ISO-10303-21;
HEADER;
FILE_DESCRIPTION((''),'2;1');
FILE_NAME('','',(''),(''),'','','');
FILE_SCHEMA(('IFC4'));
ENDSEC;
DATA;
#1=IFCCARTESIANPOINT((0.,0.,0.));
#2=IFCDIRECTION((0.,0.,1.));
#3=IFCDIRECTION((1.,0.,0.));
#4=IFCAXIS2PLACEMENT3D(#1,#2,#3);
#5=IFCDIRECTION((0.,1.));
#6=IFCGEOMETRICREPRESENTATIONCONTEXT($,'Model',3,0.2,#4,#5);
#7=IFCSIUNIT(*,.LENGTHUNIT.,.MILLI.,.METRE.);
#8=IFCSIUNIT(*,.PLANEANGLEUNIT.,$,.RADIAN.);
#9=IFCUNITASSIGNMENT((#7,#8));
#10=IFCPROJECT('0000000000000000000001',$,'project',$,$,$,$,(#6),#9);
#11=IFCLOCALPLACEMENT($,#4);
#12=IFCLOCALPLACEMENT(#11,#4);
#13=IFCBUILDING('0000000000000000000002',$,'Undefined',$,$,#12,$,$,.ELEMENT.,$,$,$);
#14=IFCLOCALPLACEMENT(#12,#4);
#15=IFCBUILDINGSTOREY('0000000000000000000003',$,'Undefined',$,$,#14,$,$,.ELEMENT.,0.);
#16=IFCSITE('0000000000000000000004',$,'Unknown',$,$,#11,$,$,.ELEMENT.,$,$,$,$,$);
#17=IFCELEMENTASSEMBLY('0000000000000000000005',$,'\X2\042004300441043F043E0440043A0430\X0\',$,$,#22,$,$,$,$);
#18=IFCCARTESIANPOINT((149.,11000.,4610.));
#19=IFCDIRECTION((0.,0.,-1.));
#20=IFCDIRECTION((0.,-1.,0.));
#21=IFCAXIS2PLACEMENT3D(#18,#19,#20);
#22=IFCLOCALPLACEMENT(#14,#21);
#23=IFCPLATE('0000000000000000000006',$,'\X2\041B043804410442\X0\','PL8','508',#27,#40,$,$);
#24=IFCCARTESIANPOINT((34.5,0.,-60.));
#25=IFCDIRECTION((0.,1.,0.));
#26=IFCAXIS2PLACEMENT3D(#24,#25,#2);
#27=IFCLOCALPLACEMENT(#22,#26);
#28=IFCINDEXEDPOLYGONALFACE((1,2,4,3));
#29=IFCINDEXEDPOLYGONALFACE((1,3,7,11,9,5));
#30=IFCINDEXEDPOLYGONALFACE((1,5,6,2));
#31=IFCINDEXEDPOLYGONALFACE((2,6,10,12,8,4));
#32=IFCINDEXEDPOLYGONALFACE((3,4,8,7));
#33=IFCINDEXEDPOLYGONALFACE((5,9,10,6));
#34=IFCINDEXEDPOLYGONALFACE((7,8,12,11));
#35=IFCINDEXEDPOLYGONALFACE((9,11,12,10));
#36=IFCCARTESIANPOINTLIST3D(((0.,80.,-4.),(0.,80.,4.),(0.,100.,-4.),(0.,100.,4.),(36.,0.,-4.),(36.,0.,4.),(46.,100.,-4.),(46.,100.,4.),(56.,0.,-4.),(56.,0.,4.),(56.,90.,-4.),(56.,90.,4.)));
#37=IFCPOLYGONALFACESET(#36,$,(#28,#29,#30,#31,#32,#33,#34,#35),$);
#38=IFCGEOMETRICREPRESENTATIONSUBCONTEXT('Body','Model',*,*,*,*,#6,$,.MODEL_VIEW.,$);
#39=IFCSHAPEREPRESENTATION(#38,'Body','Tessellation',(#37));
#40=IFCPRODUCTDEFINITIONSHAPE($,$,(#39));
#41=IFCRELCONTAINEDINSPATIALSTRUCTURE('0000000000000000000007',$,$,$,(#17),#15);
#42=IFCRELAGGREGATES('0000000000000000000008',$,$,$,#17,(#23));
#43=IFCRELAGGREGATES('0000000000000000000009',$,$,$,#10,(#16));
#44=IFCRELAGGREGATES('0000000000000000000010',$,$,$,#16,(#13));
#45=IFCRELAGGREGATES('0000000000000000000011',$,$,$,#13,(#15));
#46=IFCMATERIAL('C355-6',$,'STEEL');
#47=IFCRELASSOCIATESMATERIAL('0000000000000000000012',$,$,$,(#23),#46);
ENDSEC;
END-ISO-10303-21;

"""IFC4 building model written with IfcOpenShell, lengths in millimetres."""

from ifc_helpers import new_model, si_unit, direction, frame, origin_with_axes, place, context, subcontext, project, spatial, line, indexed_curve, outline, extrude, material, element, aggregate, save


model = new_model("IFC4")

# Units and contexts
model_context = context("Model", 3, precision=0.2, world=origin_with_axes(), true_north=direction((0.0, 1.0)))
body_context = subcontext(model_context, "Body", "Model", "MODEL_VIEW")
ifc_project = project(units=[si_unit("LENGTHUNIT", "METRE", prefix="MILLI"), si_unit("PLANEANGLEUNIT", "RADIAN")], contexts=[model_context])

# Site, building, storey
site_placement = place(None, origin_with_axes())
site = spatial("IfcSite", under=ifc_project, at=site_placement, Name="Unknown", CompositionType="ELEMENT")
building_placement = place(site_placement, origin_with_axes())
building = spatial("IfcBuilding", under=site, at=building_placement, Name="Undefined", CompositionType="ELEMENT")
storey_placement = place(building_placement, origin_with_axes())
storey = spatial("IfcBuildingStorey", under=building, at=storey_placement, Name="Undefined", CompositionType="ELEMENT", Elevation=0.0)

# Shared definitions
ifc_material_1 = material(Name="C355-6", Category="STEEL")

# Element assembly, plate
assembly_1_placement = place(storey_placement, frame((149.0, 11000.0, 4610.0), z_axis=(0.0, 0.0, -1.0), x_axis=(0.0, -1.0, 0.0)))
assembly_1 = element("IfcElementAssembly", 1, at=assembly_1_placement, inside=storey, Name="Распорка")
plate_1_placement = place(assembly_1_placement, frame((34.5, 0.0, -60.0), z_axis=(0.0, 1.0, 0.0), x_axis=(0.0, 0.0, 1.0)))
plate_1 = element("IfcPlate", 2, at=plate_1_placement, material=ifc_material_1, Name="Лист", Description="PL8", ObjectType="508", context=body_context, shape_type="SolidModel", body=[
    extrude(outline(indexed_curve([(0.0, 80.0), (36.0, 0.0), (56.0, 0.0), (56.0, 90.0), (46.0, 100.0), (0.0, 100.0)], segments=[line(1, 2, 3, 4, 5, 6, 1)])), frame((0.0, 0.0, 4.0), z_axis=(0.0, 0.0, 1.0), x_axis=(1.0, 0.0, 0.0)), (0.0, 0.0, -1.0), 8.0),
])
aggregate(assembly_1, [plate_1])

save(model, "model.ifc")
